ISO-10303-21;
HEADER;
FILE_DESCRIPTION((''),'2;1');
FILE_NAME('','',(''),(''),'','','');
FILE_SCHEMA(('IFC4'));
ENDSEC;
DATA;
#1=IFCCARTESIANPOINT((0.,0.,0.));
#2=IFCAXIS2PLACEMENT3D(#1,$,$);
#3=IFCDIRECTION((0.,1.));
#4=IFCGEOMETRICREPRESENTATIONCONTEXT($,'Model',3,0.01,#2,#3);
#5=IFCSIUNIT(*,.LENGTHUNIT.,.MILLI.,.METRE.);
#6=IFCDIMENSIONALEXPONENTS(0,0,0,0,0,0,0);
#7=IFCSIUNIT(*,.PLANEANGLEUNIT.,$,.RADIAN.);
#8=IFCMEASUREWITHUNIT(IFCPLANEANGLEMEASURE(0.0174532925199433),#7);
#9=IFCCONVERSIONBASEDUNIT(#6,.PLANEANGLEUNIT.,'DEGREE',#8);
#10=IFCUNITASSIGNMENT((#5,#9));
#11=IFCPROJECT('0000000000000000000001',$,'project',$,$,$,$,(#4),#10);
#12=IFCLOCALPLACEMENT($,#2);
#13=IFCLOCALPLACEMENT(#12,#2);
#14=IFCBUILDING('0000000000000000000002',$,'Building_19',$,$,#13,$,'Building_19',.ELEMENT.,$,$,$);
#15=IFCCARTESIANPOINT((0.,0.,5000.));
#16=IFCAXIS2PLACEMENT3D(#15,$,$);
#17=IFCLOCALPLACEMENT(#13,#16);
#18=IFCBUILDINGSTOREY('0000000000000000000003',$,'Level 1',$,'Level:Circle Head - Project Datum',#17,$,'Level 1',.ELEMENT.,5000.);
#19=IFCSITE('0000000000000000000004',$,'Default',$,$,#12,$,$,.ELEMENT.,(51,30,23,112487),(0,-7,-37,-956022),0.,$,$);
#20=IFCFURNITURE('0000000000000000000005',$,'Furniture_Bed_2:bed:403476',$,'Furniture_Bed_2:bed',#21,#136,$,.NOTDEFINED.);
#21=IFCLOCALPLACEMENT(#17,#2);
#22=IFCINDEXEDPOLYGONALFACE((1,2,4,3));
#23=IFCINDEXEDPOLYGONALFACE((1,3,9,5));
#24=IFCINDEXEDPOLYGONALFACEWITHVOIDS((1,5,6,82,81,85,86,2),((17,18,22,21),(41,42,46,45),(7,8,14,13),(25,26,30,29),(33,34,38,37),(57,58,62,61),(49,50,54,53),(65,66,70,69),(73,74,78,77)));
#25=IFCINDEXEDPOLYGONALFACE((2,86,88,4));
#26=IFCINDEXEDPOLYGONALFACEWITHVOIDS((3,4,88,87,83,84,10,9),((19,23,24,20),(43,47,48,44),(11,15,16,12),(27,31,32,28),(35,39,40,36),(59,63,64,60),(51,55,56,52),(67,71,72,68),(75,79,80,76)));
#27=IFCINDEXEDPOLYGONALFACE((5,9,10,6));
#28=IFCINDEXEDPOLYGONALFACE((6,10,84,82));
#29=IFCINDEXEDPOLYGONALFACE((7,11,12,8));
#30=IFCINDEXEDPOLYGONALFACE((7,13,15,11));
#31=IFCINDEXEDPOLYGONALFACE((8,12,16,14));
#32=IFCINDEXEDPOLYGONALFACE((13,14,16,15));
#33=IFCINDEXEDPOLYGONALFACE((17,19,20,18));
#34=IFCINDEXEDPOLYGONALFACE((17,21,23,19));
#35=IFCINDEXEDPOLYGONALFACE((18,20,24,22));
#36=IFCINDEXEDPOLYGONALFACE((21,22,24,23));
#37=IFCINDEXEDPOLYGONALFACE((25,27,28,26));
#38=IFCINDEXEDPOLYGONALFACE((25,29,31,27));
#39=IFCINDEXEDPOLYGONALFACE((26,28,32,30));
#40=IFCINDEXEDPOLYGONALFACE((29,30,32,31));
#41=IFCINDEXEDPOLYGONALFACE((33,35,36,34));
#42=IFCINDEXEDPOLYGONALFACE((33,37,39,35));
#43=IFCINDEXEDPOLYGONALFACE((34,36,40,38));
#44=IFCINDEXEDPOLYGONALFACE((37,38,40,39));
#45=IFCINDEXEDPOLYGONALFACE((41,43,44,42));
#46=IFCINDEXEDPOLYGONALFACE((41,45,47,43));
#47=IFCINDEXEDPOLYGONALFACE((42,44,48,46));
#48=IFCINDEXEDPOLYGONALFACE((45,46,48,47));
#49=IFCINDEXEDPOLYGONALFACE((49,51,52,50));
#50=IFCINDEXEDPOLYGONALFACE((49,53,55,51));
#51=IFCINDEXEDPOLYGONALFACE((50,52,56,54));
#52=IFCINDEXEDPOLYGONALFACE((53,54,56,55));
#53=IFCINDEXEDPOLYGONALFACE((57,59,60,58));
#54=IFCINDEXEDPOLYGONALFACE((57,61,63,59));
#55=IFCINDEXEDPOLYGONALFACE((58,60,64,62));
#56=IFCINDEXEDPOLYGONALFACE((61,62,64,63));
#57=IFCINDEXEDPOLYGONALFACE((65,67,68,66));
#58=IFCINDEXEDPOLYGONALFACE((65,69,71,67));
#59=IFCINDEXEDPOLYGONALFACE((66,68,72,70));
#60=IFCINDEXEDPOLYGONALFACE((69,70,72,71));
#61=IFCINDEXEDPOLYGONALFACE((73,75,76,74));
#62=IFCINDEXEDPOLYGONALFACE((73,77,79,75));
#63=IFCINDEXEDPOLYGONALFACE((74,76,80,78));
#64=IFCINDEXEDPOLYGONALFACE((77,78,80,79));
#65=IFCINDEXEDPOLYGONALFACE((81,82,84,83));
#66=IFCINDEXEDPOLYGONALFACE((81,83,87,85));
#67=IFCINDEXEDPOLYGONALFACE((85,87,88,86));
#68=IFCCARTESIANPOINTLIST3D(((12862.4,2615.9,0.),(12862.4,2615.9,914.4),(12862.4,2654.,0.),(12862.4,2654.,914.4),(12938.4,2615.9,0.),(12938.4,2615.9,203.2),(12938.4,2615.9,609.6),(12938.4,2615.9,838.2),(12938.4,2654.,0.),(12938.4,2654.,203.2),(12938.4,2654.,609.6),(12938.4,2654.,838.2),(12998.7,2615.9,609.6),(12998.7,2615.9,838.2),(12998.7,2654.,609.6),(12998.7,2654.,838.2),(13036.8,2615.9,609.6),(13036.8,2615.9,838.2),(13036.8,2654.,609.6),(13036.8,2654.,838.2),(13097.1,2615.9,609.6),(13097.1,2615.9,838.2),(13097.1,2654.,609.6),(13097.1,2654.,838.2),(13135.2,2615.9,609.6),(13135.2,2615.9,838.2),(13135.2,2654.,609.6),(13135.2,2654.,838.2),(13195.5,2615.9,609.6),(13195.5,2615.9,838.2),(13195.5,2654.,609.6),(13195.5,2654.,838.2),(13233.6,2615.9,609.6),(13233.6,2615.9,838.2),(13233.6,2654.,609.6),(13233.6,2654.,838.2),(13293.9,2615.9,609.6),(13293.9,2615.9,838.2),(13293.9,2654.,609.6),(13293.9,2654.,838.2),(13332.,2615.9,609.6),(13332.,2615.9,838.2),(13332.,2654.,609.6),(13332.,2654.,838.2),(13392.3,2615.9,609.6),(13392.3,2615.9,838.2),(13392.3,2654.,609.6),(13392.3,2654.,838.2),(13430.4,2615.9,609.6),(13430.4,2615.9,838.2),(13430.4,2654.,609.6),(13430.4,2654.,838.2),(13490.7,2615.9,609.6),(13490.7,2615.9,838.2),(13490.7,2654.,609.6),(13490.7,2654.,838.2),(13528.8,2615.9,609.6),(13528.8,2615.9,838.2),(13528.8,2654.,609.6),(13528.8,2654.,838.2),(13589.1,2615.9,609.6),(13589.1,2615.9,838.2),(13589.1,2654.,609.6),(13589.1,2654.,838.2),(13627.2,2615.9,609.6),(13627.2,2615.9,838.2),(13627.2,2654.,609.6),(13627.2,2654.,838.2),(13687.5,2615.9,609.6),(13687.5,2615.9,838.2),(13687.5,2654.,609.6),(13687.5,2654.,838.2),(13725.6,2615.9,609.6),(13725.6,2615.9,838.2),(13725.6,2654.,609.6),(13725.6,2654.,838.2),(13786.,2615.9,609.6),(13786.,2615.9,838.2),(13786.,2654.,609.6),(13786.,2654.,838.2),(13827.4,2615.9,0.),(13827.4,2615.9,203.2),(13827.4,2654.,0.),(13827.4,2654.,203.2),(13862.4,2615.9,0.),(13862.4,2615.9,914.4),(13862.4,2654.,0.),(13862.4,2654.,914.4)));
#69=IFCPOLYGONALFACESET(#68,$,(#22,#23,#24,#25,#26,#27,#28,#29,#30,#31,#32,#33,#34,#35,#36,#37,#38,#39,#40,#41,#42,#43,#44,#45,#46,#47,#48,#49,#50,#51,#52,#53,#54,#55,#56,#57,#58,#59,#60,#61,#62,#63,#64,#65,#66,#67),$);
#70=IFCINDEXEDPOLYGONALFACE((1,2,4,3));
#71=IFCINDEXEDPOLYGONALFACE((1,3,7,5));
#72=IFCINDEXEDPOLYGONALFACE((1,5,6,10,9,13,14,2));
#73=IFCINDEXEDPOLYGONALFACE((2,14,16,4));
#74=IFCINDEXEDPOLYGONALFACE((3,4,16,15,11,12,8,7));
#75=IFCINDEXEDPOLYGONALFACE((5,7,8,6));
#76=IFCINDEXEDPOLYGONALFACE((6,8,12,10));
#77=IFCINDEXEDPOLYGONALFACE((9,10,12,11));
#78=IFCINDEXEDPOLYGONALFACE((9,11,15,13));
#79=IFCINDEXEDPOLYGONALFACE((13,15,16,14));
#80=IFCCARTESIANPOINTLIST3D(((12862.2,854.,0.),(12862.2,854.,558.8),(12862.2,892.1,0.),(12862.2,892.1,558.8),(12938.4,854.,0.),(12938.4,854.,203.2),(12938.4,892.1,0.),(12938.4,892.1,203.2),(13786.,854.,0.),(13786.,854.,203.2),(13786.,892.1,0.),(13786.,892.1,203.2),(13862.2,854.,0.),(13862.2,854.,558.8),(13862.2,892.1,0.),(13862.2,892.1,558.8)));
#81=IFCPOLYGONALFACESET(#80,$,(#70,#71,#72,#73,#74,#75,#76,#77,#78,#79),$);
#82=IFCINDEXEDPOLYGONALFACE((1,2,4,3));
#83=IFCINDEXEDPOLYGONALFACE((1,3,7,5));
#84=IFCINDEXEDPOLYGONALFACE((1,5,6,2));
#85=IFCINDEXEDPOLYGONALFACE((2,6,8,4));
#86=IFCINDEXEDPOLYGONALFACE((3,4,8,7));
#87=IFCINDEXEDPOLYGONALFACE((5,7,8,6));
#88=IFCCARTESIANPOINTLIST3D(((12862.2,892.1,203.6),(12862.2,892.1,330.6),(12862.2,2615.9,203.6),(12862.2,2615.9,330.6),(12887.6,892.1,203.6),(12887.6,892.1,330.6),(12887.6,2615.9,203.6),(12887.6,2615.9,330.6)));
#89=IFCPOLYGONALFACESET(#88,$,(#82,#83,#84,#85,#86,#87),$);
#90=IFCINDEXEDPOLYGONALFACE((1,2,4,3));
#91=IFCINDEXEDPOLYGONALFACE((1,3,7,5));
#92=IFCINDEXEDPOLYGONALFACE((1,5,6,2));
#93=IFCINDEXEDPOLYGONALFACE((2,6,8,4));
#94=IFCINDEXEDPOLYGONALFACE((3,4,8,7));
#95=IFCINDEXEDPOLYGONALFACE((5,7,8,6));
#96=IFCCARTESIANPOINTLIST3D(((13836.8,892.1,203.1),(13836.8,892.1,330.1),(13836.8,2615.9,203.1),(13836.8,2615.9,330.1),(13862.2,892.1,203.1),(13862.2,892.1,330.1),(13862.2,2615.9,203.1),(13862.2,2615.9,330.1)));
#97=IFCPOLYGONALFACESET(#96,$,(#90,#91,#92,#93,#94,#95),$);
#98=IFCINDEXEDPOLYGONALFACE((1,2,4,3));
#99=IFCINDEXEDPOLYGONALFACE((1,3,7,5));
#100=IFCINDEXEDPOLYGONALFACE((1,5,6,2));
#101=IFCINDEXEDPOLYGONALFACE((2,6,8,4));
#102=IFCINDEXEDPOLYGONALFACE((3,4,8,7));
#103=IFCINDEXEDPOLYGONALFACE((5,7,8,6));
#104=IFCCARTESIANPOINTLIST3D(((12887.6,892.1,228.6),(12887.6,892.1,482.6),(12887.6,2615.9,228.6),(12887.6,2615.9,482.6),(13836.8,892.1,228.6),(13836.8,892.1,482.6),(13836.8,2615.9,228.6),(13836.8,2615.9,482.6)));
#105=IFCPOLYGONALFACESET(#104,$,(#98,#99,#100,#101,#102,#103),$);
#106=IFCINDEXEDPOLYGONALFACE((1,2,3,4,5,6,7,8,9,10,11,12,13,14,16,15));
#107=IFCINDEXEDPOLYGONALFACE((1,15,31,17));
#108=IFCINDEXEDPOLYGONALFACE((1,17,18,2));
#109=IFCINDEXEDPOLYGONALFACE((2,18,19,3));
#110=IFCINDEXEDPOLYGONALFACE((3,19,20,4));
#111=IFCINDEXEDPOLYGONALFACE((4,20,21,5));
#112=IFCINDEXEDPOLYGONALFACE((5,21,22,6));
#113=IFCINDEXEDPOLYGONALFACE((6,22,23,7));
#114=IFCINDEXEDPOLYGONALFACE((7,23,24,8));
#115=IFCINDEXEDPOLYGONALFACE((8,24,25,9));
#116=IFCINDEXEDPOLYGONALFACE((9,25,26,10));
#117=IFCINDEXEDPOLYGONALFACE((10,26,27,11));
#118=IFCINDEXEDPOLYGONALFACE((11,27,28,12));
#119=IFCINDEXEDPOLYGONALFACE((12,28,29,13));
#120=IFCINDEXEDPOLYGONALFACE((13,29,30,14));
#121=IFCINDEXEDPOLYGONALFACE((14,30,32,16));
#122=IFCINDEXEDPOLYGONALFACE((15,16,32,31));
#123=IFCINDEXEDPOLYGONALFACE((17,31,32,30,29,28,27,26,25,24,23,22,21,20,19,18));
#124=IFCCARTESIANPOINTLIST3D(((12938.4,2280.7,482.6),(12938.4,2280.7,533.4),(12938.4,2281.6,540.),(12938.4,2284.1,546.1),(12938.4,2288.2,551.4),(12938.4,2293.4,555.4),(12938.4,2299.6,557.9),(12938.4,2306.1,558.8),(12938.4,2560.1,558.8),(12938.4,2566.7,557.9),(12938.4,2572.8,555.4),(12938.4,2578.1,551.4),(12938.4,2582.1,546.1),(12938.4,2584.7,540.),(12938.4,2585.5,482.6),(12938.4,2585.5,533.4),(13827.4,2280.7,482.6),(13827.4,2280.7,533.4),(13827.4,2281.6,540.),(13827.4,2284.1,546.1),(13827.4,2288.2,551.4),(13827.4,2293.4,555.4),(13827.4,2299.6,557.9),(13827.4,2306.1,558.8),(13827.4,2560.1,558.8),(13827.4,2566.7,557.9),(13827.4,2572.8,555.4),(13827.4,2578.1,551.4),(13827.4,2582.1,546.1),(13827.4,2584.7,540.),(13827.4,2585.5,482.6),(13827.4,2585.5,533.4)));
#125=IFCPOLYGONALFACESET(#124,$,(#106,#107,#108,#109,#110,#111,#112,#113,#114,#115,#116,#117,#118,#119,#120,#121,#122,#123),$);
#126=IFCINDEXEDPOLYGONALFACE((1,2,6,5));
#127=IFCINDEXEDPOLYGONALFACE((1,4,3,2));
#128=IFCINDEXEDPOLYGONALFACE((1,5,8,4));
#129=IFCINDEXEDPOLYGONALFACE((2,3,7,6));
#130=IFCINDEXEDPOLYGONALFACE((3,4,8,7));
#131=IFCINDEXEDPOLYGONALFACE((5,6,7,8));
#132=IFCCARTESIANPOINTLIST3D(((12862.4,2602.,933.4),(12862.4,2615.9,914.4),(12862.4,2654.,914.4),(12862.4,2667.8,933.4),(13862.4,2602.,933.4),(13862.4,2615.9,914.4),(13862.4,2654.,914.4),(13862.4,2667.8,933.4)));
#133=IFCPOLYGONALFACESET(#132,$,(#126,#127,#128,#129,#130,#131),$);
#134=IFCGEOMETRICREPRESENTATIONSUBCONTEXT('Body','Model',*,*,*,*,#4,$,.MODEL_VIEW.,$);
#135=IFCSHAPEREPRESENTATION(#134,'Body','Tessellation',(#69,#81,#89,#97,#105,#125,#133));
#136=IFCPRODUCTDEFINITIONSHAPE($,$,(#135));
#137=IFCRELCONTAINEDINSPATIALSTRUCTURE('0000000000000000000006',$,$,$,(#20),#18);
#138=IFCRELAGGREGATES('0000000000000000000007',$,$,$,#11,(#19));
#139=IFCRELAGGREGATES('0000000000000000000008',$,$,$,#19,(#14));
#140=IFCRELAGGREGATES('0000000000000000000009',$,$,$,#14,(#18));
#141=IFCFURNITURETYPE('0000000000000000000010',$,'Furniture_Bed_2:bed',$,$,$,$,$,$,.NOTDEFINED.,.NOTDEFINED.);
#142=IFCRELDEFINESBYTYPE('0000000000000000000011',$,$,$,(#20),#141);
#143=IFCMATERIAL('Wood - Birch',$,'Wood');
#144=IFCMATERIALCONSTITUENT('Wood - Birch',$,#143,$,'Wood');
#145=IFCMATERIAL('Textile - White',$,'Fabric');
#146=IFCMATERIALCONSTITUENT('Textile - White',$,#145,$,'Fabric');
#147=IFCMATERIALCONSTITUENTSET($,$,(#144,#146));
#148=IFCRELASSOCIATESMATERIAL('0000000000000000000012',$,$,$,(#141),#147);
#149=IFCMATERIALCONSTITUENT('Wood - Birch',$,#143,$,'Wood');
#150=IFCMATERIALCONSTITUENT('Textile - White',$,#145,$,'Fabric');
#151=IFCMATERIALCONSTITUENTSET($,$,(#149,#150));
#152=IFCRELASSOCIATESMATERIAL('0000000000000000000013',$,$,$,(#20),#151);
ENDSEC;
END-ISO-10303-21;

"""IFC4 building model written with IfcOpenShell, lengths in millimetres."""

from ifc_helpers import new_model, entity, si_unit, converted_unit, direction, frame, origin, place, context, subcontext, project, spatial, line, arc, indexed_curve, outline, extrude, source, transform, mapped, material, constituent, constituent_set, type_object, type_shapes, element, save


model = new_model("IFC4")

# Units and contexts
model_context = context("Model", 3, precision=0.01, world=origin(), true_north=direction((0.0, 1.0)))
body_context = subcontext(model_context, "Body", "Model", "MODEL_VIEW")
ifc_project = project(units=[si_unit("LENGTHUNIT", "METRE", prefix="MILLI"), converted_unit("PLANEANGLEUNIT", "DEGREE", entity("IfcPlaneAngleMeasure", 0.0174532925199433), si_unit("PLANEANGLEUNIT", "RADIAN"), dimensions=[0, 0, 0, 0, 0, 0, 0])], contexts=[model_context])

# Site, building, storey
site_placement = place(None, origin())
site = spatial("IfcSite", under=ifc_project, at=site_placement, Name="Default", CompositionType="ELEMENT", RefLatitude=(51, 30, 23, 112487), RefLongitude=(0, -7, -37, -956022), RefElevation=0.0)
building_placement = place(site_placement, origin())
building = spatial("IfcBuilding", under=site, at=building_placement, Name="Building_19", LongName="Building_19", CompositionType="ELEMENT")
storey_placement = place(building_placement, frame((0.0, 0.0, 5000.0)))
storey = spatial("IfcBuildingStorey", under=building, at=storey_placement, Name="Level 1", ObjectType="Level:Circle Head - Project Datum", LongName="Level 1", CompositionType="ELEMENT", Elevation=5000.0)

# Furniture
ifc_material_1 = material(Name="Wood - Birch", Category="Wood")
ifc_material_2 = material(Name="Textile - White", Category="Fabric")
ifc_constituent_1 = constituent(ifc_material_1, Name="Wood - Birch", Category="Wood")
ifc_constituent_2 = constituent(ifc_material_2, Name="Textile - White", Category="Fabric")
ifc_constituent_set_1 = constituent_set(constituents=[ifc_constituent_1, ifc_constituent_2])
furniture_type_1 = type_object("IfcFurnitureType", Name="Furniture_Bed_2:bed", AssemblyPlace="NOTDEFINED", PredefinedType="NOTDEFINED", material=ifc_constituent_set_1)
shared_shape_1 = source(origin(), body_context, "Body", "SweptSolid", [
    extrude(outline(indexed_curve([(-635.0, -489.8), (279.4, -489.8), (279.4, -454.7), (76.2, -454.7), (76.2, 434.3), (279.4, 434.3), (279.4, 510.3), (-635.0, 510.3), (-635.0, -489.8)], self_intersect=False), holes=[indexed_curve([(-558.8, 374.0), (-558.8, 434.3), (-330.2, 434.3), (-330.2, 374.0), (-558.8, 374.0)], self_intersect=False), indexed_curve([(-558.8, 275.5), (-558.8, 335.9), (-330.2, 335.9), (-330.2, 275.5), (-558.8, 275.5)], self_intersect=False), indexed_curve([(-558.8, 177.1), (-558.8, 237.4), (-330.2, 237.4), (-330.2, 177.1), (-558.8, 177.1)], self_intersect=False), indexed_curve([(-558.8, 78.7), (-558.8, 139.0), (-330.2, 139.0), (-330.2, 78.7), (-558.8, 78.7)], self_intersect=False), indexed_curve([(-558.8, -118.1), (-558.8, -57.8), (-330.2, -57.8), (-330.2, -118.1), (-558.8, -118.1)], self_intersect=False), indexed_curve([(-558.8, -216.5), (-558.8, -156.2), (-330.2, -156.2), (-330.2, -216.5), (-558.8, -216.5)], self_intersect=False), indexed_curve([(-558.8, -314.9), (-558.8, -254.6), (-330.2, -254.6), (-330.2, -314.9), (-558.8, -314.9)], self_intersect=False), indexed_curve([(-558.8, -413.3), (-558.8, -353.0), (-330.2, -353.0), (-330.2, -413.3), (-558.8, -413.3)], self_intersect=False), indexed_curve([(-558.8, -19.7), (-558.8, 40.6), (-330.2, 40.6), (-330.2, -19.7), (-558.8, -19.7)], self_intersect=False)]), frame((-8.6, -38.1, 279.4), z_axis=(0.0, 1.0, 0.0), x_axis=(0.0, 0.0, -1.0)), (0.0, 0.0, 1.0), 38.1),
    extrude(outline(indexed_curve([(423.8, -190.5), (500.0, -190.5), (500.0, 368.3), (-500.0, 368.3), (-500.0, -190.5), (-423.8, -190.5), (-423.8, 12.7), (423.8, 12.7), (423.8, -190.5)], self_intersect=False)), frame((-19.1, -1800.0, 190.5), z_axis=(0.0, 1.0, 0.0), x_axis=(-1.0, 0.0, 0.0)), (0.0, 0.0, 1.0), 38.1),
    extrude(outline(indexed_curve([(-12.7, -861.9), (12.7, -861.9), (12.7, 861.9), (-12.7, 861.9), (-12.7, -861.9)], self_intersect=False)), frame((-506.4, -900.0, 203.6)), (0.0, 0.0, 1.0), 127.0),
    extrude(outline(indexed_curve([(-12.7, -861.9), (12.7, -861.9), (12.7, 861.9), (-12.7, 861.9), (-12.7, -861.9)], self_intersect=False)), frame((468.2, -900.0, 203.1)), (0.0, 0.0, 1.0), 127.0),
    extrude(outline(indexed_curve([(-474.6, -861.9), (474.6, -861.9), (474.6, 861.9), (-474.6, 861.9), (-474.6, -861.9)], self_intersect=False)), frame((-19.0, -900.0, 228.6), z_axis=(0.0, 0.0, 1.0), x_axis=(-1.0, 0.0, 0.0)), (0.0, 0.0, 1.0), 254.0),
    extrude(outline(indexed_curve([(-152.4, -42.3), (152.4, -42.3), (152.4, 8.5), (145.0, 26.4), (127.0, 33.9), (-127.0, 33.9), (-145.0, 26.4), (-152.4, 8.5)], segments=[line(1, 2, 3), arc(3, 4, 5), line(5, 6), arc(6, 7, 8), line(8, 1)], self_intersect=False)), frame((-442.9, -220.8, 524.9), z_axis=(1.0, 0.0, 0.0), x_axis=(0.0, 1.0, 0.0)), (0.0, 0.0, 1.0), 889.0),
    extrude(outline(indexed_curve([(-19.1, -9.5), (19.0, -9.5), (32.9, 9.5), (-32.9, 9.5), (-19.1, -9.5)], self_intersect=False)), frame((-518.8, -19.0, 923.9), z_axis=(1.0, 0.0, 0.0), x_axis=(0.0, 1.0, 0.0)), (0.0, 0.0, 1.0), 1000.1),
])
type_shapes(furniture_type_1, [shared_shape_1])
ifc_constituent_3 = constituent(ifc_material_1, Name="Wood - Birch", Category="Wood")
ifc_constituent_4 = constituent(ifc_material_2, Name="Textile - White", Category="Fabric")
ifc_constituent_set_2 = constituent_set(constituents=[ifc_constituent_3, ifc_constituent_4])
furniture_1_placement = place(storey_placement, frame((13381.2, 2654.0, 0.0)))
element("IfcFurniture", 1, at=furniture_1_placement, inside=storey, type_object=furniture_type_1, material=ifc_constituent_set_2, Name="Furniture_Bed_2:bed:403476", ObjectType="Furniture_Bed_2:bed", PredefinedType="NOTDEFINED", context=body_context, shape_type="MappedRepresentation", body=[
    mapped(shared_shape_1, transform((0.0, 0.0, 0.0), scale=1.0)),
])

save(model, "model.ifc")
